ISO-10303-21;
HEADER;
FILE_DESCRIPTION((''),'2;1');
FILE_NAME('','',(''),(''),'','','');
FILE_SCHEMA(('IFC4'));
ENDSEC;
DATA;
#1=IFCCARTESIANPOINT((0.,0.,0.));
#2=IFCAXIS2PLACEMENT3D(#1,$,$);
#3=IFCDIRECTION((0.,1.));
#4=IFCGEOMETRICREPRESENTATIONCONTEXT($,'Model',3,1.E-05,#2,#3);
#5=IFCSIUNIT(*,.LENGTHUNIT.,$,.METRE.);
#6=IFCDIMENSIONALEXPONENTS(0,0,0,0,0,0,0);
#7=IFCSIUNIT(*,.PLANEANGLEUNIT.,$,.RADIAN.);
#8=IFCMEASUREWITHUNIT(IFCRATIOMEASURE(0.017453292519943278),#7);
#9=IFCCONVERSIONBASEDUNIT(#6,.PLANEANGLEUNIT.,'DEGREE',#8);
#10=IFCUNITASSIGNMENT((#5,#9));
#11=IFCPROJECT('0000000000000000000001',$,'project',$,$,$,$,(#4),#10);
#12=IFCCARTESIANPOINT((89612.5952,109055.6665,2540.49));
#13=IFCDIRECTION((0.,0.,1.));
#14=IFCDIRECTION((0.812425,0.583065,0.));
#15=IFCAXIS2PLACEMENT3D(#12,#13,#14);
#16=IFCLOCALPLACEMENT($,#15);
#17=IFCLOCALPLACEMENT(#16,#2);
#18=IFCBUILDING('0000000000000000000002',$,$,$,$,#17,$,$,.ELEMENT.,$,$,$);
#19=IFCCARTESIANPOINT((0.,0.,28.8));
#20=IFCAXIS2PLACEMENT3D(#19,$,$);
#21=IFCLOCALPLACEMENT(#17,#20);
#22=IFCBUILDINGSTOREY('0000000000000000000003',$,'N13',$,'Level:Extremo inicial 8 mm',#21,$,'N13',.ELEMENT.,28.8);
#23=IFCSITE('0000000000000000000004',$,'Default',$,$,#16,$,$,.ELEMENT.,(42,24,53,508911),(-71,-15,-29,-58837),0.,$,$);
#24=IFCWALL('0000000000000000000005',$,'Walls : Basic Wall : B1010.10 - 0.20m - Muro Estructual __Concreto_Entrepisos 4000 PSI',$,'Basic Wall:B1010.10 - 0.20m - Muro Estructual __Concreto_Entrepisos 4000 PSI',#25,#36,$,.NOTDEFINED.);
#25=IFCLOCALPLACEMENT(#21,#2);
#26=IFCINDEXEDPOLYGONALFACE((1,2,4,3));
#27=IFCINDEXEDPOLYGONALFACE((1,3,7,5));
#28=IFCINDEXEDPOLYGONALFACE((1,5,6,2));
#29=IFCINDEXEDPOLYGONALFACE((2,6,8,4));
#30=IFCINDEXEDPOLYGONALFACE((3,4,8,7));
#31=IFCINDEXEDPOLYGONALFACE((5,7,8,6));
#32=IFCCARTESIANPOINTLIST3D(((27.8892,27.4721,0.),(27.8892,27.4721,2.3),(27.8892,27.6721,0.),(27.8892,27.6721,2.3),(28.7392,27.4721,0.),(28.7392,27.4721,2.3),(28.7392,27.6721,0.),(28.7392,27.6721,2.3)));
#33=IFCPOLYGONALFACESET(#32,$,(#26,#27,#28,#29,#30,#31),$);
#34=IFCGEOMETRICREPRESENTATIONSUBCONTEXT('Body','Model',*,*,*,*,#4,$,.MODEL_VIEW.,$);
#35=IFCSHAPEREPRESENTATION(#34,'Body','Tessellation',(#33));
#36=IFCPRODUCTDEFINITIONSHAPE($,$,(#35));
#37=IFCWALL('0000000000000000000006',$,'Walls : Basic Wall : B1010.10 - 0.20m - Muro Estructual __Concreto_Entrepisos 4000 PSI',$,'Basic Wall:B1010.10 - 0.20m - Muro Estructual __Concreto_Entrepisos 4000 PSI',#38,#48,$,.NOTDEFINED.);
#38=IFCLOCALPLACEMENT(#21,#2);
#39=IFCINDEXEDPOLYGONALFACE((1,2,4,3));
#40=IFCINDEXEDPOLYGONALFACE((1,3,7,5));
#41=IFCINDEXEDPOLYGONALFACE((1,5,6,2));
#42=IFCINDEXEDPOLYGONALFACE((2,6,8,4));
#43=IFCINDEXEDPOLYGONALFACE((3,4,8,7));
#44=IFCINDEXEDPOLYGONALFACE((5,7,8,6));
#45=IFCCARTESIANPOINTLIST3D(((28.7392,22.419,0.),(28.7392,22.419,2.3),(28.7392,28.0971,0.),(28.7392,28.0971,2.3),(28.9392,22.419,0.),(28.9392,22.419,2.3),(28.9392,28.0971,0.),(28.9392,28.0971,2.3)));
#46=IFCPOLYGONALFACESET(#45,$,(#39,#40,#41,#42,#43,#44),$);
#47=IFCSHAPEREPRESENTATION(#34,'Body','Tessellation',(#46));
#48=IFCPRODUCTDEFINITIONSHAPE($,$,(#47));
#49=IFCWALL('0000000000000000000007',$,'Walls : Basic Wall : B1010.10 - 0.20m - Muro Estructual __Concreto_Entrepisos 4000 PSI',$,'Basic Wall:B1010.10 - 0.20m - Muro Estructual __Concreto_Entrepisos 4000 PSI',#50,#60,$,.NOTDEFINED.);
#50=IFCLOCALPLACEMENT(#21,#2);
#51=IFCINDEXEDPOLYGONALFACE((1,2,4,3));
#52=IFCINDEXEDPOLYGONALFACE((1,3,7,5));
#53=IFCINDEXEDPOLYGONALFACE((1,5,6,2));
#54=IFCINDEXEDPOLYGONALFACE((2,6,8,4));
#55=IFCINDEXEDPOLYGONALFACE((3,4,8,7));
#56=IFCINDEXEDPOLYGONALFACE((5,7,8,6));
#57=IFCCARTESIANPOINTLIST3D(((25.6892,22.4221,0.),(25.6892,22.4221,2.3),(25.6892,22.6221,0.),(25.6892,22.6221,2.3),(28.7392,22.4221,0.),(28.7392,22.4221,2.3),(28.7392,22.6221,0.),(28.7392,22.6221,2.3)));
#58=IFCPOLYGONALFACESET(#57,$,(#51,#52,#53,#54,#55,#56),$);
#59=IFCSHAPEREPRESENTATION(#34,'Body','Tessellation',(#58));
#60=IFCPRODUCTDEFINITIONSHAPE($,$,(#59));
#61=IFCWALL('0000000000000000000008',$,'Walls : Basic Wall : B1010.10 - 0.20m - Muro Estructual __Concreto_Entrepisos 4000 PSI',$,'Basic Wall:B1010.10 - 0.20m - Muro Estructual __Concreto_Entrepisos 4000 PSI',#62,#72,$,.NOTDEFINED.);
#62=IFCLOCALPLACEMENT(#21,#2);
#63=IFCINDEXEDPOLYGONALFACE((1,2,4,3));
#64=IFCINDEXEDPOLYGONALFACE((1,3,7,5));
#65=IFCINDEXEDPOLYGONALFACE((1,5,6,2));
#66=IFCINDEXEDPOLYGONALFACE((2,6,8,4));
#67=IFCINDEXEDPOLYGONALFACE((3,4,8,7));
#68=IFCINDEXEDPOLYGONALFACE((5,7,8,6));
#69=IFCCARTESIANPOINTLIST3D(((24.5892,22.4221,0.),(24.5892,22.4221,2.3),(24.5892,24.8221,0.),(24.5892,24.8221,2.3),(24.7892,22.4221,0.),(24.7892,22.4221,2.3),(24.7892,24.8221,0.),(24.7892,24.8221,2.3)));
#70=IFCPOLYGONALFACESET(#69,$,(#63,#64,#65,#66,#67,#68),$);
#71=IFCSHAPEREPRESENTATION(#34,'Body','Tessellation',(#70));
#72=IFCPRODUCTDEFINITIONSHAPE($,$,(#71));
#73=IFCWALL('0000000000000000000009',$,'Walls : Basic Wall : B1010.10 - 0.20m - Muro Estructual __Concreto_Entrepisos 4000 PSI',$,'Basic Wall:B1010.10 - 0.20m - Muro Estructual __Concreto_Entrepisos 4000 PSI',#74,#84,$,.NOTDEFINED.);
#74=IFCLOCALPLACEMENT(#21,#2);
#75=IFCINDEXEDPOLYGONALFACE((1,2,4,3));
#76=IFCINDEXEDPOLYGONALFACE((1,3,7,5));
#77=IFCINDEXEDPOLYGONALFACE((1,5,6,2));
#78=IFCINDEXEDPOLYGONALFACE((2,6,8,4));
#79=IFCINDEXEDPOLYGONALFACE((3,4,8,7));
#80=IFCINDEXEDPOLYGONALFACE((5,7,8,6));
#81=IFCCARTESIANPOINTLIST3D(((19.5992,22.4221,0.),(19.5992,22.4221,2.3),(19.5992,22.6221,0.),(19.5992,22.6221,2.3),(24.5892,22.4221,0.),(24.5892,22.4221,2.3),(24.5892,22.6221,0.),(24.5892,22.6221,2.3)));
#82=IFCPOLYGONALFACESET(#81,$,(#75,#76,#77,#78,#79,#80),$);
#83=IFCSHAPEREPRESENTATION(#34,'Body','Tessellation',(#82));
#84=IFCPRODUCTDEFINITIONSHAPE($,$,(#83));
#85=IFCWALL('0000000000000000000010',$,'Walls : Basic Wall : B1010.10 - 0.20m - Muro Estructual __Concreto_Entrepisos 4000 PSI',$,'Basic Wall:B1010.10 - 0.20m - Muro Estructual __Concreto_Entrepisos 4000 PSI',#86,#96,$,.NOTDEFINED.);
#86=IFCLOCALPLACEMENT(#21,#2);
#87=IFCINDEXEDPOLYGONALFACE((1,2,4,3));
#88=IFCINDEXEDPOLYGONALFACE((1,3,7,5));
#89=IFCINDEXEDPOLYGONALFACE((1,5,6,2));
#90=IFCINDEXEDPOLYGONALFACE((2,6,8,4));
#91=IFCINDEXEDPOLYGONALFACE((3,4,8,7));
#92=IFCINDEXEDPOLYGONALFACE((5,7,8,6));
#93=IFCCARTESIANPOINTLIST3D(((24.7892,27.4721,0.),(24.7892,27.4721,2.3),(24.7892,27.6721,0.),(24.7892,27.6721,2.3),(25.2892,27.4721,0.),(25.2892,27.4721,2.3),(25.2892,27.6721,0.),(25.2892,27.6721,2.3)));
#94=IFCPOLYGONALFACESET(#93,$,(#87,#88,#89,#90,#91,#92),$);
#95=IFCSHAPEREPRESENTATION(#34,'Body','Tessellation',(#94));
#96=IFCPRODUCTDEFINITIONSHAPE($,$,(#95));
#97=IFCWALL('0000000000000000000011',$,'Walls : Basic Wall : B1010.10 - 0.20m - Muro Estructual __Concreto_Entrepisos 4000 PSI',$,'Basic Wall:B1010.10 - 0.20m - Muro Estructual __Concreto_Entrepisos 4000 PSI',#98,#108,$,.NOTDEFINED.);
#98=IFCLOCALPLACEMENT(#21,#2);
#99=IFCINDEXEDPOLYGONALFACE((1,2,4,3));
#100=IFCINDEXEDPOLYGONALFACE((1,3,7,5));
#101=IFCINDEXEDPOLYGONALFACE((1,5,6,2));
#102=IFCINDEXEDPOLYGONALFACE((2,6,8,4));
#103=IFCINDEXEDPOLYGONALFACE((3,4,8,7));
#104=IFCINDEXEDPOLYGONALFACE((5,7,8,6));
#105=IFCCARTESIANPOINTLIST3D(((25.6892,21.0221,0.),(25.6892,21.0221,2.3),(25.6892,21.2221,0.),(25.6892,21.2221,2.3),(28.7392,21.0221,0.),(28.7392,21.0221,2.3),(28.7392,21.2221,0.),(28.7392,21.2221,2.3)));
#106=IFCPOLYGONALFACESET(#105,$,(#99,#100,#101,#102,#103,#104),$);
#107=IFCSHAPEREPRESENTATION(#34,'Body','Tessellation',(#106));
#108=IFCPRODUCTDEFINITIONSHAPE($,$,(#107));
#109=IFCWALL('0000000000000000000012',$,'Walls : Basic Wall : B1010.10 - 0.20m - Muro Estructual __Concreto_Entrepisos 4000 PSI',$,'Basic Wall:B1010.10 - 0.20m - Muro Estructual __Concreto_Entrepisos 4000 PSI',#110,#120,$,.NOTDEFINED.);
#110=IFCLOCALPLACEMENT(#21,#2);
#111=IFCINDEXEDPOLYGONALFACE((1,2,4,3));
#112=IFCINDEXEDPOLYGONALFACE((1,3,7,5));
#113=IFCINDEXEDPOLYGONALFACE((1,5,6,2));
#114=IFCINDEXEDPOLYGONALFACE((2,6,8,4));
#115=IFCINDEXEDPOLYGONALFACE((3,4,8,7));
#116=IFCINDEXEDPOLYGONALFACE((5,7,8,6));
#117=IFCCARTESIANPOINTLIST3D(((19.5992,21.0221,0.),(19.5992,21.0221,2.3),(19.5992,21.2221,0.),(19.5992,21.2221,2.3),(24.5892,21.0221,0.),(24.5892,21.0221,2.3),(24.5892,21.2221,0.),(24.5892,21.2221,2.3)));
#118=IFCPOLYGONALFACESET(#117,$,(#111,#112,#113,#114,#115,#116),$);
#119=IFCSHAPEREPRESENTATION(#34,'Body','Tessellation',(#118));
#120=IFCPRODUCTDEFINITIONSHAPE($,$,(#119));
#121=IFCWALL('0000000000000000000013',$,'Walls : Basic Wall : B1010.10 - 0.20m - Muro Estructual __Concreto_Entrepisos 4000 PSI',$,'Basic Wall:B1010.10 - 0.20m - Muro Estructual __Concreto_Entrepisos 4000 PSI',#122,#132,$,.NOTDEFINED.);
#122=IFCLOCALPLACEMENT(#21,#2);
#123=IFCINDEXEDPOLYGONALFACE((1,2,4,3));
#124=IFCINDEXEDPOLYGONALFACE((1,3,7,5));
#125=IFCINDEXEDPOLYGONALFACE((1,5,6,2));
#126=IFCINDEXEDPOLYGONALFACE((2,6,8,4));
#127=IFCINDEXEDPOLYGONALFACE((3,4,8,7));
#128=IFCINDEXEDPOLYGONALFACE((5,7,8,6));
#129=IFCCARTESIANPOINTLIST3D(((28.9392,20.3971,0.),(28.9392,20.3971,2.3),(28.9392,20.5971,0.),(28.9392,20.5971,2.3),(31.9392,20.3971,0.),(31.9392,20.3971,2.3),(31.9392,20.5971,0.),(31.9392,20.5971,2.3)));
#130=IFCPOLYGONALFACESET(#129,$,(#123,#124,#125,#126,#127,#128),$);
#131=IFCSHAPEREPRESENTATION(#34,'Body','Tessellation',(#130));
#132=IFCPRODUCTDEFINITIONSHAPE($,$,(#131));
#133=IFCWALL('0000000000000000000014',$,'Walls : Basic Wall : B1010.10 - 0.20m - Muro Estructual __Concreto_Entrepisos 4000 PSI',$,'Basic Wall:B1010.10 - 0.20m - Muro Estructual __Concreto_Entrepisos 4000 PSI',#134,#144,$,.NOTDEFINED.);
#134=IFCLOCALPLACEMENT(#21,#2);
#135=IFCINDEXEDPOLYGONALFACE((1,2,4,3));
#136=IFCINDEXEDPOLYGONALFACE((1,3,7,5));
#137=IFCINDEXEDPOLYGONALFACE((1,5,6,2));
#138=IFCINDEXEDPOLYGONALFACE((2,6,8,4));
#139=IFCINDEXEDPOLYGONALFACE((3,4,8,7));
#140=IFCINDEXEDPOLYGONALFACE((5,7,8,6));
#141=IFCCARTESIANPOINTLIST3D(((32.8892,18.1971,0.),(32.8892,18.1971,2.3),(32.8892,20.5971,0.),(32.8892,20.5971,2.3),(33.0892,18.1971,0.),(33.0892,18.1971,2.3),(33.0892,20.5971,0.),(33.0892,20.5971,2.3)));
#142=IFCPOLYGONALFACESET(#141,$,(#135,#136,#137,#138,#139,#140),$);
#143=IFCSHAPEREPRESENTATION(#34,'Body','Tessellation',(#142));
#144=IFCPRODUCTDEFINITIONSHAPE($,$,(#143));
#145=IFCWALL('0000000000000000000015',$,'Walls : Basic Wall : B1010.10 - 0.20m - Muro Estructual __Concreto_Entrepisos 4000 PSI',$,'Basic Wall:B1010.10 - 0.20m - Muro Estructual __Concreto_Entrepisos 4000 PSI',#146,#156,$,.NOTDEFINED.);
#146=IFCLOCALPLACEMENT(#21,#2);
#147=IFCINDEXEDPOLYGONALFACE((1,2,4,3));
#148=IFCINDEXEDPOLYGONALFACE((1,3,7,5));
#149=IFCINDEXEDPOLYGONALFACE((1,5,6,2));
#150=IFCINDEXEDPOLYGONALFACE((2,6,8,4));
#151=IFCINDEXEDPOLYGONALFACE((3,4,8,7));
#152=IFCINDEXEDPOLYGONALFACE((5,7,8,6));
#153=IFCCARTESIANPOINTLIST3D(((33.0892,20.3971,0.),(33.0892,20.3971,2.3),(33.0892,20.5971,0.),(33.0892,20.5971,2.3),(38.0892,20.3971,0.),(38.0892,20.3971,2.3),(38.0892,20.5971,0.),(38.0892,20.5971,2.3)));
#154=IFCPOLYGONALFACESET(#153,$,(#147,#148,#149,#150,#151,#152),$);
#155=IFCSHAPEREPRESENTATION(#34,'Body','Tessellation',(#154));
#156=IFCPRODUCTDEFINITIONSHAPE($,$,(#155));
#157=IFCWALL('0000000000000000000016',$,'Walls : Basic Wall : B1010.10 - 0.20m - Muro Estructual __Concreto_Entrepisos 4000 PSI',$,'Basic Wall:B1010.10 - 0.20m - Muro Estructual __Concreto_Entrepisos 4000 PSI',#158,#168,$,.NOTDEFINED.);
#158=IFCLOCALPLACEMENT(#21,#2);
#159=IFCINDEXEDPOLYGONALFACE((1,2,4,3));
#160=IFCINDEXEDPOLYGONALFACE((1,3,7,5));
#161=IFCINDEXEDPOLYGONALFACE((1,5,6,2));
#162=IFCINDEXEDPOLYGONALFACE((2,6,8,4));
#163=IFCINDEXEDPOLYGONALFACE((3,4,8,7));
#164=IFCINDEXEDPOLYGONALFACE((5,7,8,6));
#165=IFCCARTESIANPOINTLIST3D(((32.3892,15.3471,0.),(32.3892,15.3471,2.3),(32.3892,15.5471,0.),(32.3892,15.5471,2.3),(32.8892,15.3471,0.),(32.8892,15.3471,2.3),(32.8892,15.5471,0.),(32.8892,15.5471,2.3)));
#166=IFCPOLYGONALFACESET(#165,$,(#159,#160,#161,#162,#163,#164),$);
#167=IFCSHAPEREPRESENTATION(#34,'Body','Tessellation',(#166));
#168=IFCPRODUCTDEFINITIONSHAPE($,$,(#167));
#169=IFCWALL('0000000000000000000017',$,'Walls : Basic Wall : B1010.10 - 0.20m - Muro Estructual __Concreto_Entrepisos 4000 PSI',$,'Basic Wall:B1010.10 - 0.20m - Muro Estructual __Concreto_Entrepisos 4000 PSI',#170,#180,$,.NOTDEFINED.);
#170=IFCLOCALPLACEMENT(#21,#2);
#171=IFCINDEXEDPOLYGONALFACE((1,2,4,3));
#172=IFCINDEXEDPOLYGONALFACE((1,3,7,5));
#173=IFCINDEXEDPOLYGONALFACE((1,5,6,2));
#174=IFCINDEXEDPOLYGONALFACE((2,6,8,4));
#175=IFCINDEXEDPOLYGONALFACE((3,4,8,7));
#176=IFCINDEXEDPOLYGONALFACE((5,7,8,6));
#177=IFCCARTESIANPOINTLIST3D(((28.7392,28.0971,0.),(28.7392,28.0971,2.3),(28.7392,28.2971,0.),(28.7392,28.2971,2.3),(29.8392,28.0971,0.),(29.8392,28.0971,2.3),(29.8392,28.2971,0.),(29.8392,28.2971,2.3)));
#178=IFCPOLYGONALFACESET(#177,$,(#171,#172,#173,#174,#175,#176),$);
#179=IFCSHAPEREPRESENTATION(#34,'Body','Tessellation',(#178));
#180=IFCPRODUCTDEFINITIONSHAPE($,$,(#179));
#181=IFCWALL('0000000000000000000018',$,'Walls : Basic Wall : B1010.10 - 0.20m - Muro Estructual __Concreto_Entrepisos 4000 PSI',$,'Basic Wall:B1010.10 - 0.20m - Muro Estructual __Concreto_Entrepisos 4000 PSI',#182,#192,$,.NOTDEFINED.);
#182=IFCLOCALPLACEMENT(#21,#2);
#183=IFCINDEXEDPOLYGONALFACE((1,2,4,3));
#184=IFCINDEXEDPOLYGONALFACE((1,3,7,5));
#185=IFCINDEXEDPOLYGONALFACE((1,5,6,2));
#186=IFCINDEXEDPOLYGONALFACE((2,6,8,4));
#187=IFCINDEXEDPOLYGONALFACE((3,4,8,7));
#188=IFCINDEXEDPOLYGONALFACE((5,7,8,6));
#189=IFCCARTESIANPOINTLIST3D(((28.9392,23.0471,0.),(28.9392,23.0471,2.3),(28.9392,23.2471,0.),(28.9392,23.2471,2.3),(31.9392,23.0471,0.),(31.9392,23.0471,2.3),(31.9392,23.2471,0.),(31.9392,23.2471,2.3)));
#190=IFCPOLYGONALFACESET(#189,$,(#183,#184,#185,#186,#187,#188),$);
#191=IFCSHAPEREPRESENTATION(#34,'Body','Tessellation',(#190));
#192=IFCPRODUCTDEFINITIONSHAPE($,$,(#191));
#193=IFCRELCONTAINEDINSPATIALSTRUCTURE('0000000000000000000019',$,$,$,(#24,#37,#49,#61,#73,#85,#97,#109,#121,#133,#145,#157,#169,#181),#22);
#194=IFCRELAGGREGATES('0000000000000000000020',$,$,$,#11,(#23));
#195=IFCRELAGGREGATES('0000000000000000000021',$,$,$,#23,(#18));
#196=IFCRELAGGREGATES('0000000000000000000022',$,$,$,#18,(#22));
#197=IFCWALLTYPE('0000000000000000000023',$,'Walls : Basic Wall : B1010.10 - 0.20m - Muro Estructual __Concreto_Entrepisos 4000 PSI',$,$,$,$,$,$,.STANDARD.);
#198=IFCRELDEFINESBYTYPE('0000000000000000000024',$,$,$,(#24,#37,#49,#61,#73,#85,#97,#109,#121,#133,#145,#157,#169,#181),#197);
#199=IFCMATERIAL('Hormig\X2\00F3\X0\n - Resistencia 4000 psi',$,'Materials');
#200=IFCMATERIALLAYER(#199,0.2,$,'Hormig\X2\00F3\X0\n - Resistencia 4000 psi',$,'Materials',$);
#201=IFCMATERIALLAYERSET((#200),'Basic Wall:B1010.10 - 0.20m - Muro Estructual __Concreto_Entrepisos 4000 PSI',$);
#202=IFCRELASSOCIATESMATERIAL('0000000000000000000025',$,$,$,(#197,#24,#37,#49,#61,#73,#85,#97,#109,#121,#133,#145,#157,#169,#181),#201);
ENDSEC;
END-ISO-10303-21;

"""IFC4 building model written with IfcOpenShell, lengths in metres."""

from ifc_helpers import new_model, entity, si_unit, converted_unit, direction, frame, frame_2d, origin, place, context, subcontext, project, spatial, rectangle, extrude, material, layer, layer_set, layer_usage, type_object, element, save


model = new_model("IFC4")

# Units and contexts
model_context = context("Model", 3, precision=1e-05, world=origin(), true_north=direction((0.0, 1.0)))
body_context = subcontext(model_context, "Body", "Model", "MODEL_VIEW")
ifc_project = project(units=[si_unit("LENGTHUNIT", "METRE"), converted_unit("PLANEANGLEUNIT", "DEGREE", entity("IfcRatioMeasure", 0.017453292519943278), si_unit("PLANEANGLEUNIT", "RADIAN"), dimensions=[0, 0, 0, 0, 0, 0, 0])], contexts=[model_context])

# Site, building, storey
site_placement = place(None, frame((89612.5952, 109055.6665, 2540.49), z_axis=(0.0, 0.0, 1.0), x_axis=(0.812425, 0.583065, 0.0)))
site = spatial("IfcSite", under=ifc_project, at=site_placement, Name="Default", CompositionType="ELEMENT", RefLatitude=(42, 24, 53, 508911), RefLongitude=(-71, -15, -29, -58837), RefElevation=0.0)
building_placement = place(site_placement, origin())
building = spatial("IfcBuilding", under=site, at=building_placement, CompositionType="ELEMENT")
storey_placement = place(building_placement, frame((0.0, 0.0, 28.8)))
storey = spatial("IfcBuildingStorey", under=building, at=storey_placement, Name="N13", ObjectType="Level:Extremo inicial 8 mm", LongName="N13", CompositionType="ELEMENT", Elevation=28.8)

# Walls
ifc_material = material(Name="Hormigón - Resistencia 4000 psi", Category="Materials")
ifc_layer_1 = layer(ifc_material, 0.2, Name="Hormigón - Resistencia 4000 psi", Category="Materials")
ifc_layer_set_1 = layer_set([ifc_layer_1], Name="Basic Wall:B1010.10 - 0.20m - Muro Estructual __Concreto_Entrepisos 4000 PSI")
ifc_layer_usage_1 = layer_usage(ifc_layer_set_1, "AXIS2", "NEGATIVE", 0.1)
wall_type_1 = type_object("IfcWallType", Name="Walls : Basic Wall : B1010.10 - 0.20m - Muro Estructual __Concreto_Entrepisos 4000 PSI", PredefinedType="STANDARD", material=ifc_layer_set_1)
wall_1_placement = place(storey_placement, frame((27.8892, 27.5721, 0.0)))
element("IfcWall", 1, at=wall_1_placement, inside=storey, type_object=wall_type_1, material=ifc_layer_usage_1, Name="Walls : Basic Wall : B1010.10 - 0.20m - Muro Estructual __Concreto_Entrepisos 4000 PSI", ObjectType="Basic Wall:B1010.10 - 0.20m - Muro Estructual __Concreto_Entrepisos 4000 PSI", PredefinedType="NOTDEFINED", context=body_context, shape_type="SweptSolid", body=[
    extrude(rectangle(XDim=0.85, YDim=0.2, at=frame_2d((0.425, 0.0), x_axis=(-1.0, 0.0))), origin(), (0.0, 0.0, 1.0), 2.3),
])
ifc_layer_usage_2 = layer_usage(ifc_layer_set_1, "AXIS2", "NEGATIVE", 0.1)
wall_2_placement = place(storey_placement, frame((28.8392, 28.0971, 0.0), z_axis=(0.0, 0.0, 1.0), x_axis=(0.0, -1.0, 0.0)))
element("IfcWall", 2, at=wall_2_placement, inside=storey, type_object=wall_type_1, material=ifc_layer_usage_2, Name="Walls : Basic Wall : B1010.10 - 0.20m - Muro Estructual __Concreto_Entrepisos 4000 PSI", ObjectType="Basic Wall:B1010.10 - 0.20m - Muro Estructual __Concreto_Entrepisos 4000 PSI", PredefinedType="NOTDEFINED", context=body_context, shape_type="SweptSolid", body=[
    extrude(rectangle(XDim=5.6781, YDim=0.2, at=frame_2d((2.839, 0.0), x_axis=(-1.0, 0.0))), origin(), (0.0, 0.0, 1.0), 2.3),
])
ifc_layer_usage_3 = layer_usage(ifc_layer_set_1, "AXIS2", "NEGATIVE", 0.1)
wall_3_placement = place(storey_placement, frame((28.7392, 22.5221, 0.0), z_axis=(0.0, 0.0, 1.0), x_axis=(-1.0, 0.0, 0.0)))
element("IfcWall", 3, at=wall_3_placement, inside=storey, type_object=wall_type_1, material=ifc_layer_usage_3, Name="Walls : Basic Wall : B1010.10 - 0.20m - Muro Estructual __Concreto_Entrepisos 4000 PSI", ObjectType="Basic Wall:B1010.10 - 0.20m - Muro Estructual __Concreto_Entrepisos 4000 PSI", PredefinedType="NOTDEFINED", context=body_context, shape_type="SweptSolid", body=[
    extrude(rectangle(XDim=3.05, YDim=0.2, at=frame_2d((1.525, 0.0), x_axis=(-1.0, 0.0))), origin(), (0.0, 0.0, 1.0), 2.3),
])
ifc_layer_usage_4 = layer_usage(ifc_layer_set_1, "AXIS2", "NEGATIVE", 0.1)
wall_4_placement = place(storey_placement, frame((24.6892, 24.8221, 0.0), z_axis=(0.0, 0.0, 1.0), x_axis=(0.0, -1.0, 0.0)))
element("IfcWall", 4, at=wall_4_placement, inside=storey, type_object=wall_type_1, material=ifc_layer_usage_4, Name="Walls : Basic Wall : B1010.10 - 0.20m - Muro Estructual __Concreto_Entrepisos 4000 PSI", ObjectType="Basic Wall:B1010.10 - 0.20m - Muro Estructual __Concreto_Entrepisos 4000 PSI", PredefinedType="NOTDEFINED", context=body_context, shape_type="SweptSolid", body=[
    extrude(rectangle(XDim=2.4, YDim=0.2, at=frame_2d((1.2, 0.0), x_axis=(-1.0, 0.0))), origin(), (0.0, 0.0, 1.0), 2.3),
])
ifc_layer_usage_5 = layer_usage(ifc_layer_set_1, "AXIS2", "NEGATIVE", 0.1)
wall_5_placement = place(storey_placement, frame((24.5892, 22.5221, 0.0), z_axis=(0.0, 0.0, 1.0), x_axis=(-1.0, 0.0, 0.0)))
element("IfcWall", 5, at=wall_5_placement, inside=storey, type_object=wall_type_1, material=ifc_layer_usage_5, Name="Walls : Basic Wall : B1010.10 - 0.20m - Muro Estructual __Concreto_Entrepisos 4000 PSI", ObjectType="Basic Wall:B1010.10 - 0.20m - Muro Estructual __Concreto_Entrepisos 4000 PSI", PredefinedType="NOTDEFINED", context=body_context, shape_type="SweptSolid", body=[
    extrude(rectangle(XDim=4.99, YDim=0.2, at=frame_2d((2.495, 0.0), x_axis=(-1.0, 0.0))), origin(), (0.0, 0.0, 1.0), 2.3),
])
ifc_layer_usage_6 = layer_usage(ifc_layer_set_1, "AXIS2", "NEGATIVE", 0.1)
wall_6_placement = place(storey_placement, frame((25.2892, 27.5721, 0.0), z_axis=(0.0, 0.0, 1.0), x_axis=(-1.0, 0.0, 0.0)))
element("IfcWall", 6, at=wall_6_placement, inside=storey, type_object=wall_type_1, material=ifc_layer_usage_6, Name="Walls : Basic Wall : B1010.10 - 0.20m - Muro Estructual __Concreto_Entrepisos 4000 PSI", ObjectType="Basic Wall:B1010.10 - 0.20m - Muro Estructual __Concreto_Entrepisos 4000 PSI", PredefinedType="NOTDEFINED", context=body_context, shape_type="SweptSolid", body=[
    extrude(rectangle(XDim=0.5, YDim=0.2, at=frame_2d((0.25, 0.0), x_axis=(-1.0, 0.0))), origin(), (0.0, 0.0, 1.0), 2.3),
])
ifc_layer_usage_7 = layer_usage(ifc_layer_set_1, "AXIS2", "POSITIVE", -0.1)
wall_7_placement = place(storey_placement, frame((28.7392, 21.1221, 0.0), z_axis=(0.0, 0.0, 1.0), x_axis=(-1.0, 0.0, 0.0)))
element("IfcWall", 7, at=wall_7_placement, inside=storey, type_object=wall_type_1, material=ifc_layer_usage_7, Name="Walls : Basic Wall : B1010.10 - 0.20m - Muro Estructual __Concreto_Entrepisos 4000 PSI", ObjectType="Basic Wall:B1010.10 - 0.20m - Muro Estructual __Concreto_Entrepisos 4000 PSI", PredefinedType="NOTDEFINED", context=body_context, shape_type="SweptSolid", body=[
    extrude(rectangle(XDim=3.05, YDim=0.2, at=frame_2d((1.525, 0.0), x_axis=(-1.0, 0.0))), origin(), (0.0, 0.0, 1.0), 2.3),
])
ifc_layer_usage_8 = layer_usage(ifc_layer_set_1, "AXIS2", "POSITIVE", -0.1)
wall_8_placement = place(storey_placement, frame((24.5892, 21.1221, 0.0), z_axis=(0.0, 0.0, 1.0), x_axis=(-1.0, 0.0, 0.0)))
element("IfcWall", 8, at=wall_8_placement, inside=storey, type_object=wall_type_1, material=ifc_layer_usage_8, Name="Walls : Basic Wall : B1010.10 - 0.20m - Muro Estructual __Concreto_Entrepisos 4000 PSI", ObjectType="Basic Wall:B1010.10 - 0.20m - Muro Estructual __Concreto_Entrepisos 4000 PSI", PredefinedType="NOTDEFINED", context=body_context, shape_type="SweptSolid", body=[
    extrude(rectangle(XDim=4.99, YDim=0.2, at=frame_2d((2.495, 0.0), x_axis=(-1.0, 0.0))), origin(), (0.0, 0.0, 1.0), 2.3),
])
ifc_layer_usage_9 = layer_usage(ifc_layer_set_1, "AXIS2", "NEGATIVE", 0.1)
wall_9_placement = place(storey_placement, frame((28.9392, 20.4971, 0.0)))
element("IfcWall", 9, at=wall_9_placement, inside=storey, type_object=wall_type_1, material=ifc_layer_usage_9, Name="Walls : Basic Wall : B1010.10 - 0.20m - Muro Estructual __Concreto_Entrepisos 4000 PSI", ObjectType="Basic Wall:B1010.10 - 0.20m - Muro Estructual __Concreto_Entrepisos 4000 PSI", PredefinedType="NOTDEFINED", context=body_context, shape_type="SweptSolid", body=[
    extrude(rectangle(XDim=3.0, YDim=0.2, at=frame_2d((1.5, 0.0), x_axis=(-1.0, 0.0))), origin(), (0.0, 0.0, 1.0), 2.3),
])
ifc_layer_usage_10 = layer_usage(ifc_layer_set_1, "AXIS2", "NEGATIVE", 0.1)
wall_10_placement = place(storey_placement, frame((32.9892, 18.1971, 0.0), z_axis=(0.0, 0.0, 1.0), x_axis=(0.0, 1.0, 0.0)))
element("IfcWall", 10, at=wall_10_placement, inside=storey, type_object=wall_type_1, material=ifc_layer_usage_10, Name="Walls : Basic Wall : B1010.10 - 0.20m - Muro Estructual __Concreto_Entrepisos 4000 PSI", ObjectType="Basic Wall:B1010.10 - 0.20m - Muro Estructual __Concreto_Entrepisos 4000 PSI", PredefinedType="NOTDEFINED", context=body_context, shape_type="SweptSolid", body=[
    extrude(rectangle(XDim=2.4, YDim=0.2, at=frame_2d((1.2, 0.0), x_axis=(-1.0, 0.0))), origin(), (0.0, 0.0, 1.0), 2.3),
])
ifc_layer_usage_11 = layer_usage(ifc_layer_set_1, "AXIS2", "NEGATIVE", 0.1)
wall_11_placement = place(storey_placement, frame((33.0892, 20.4971, 0.0)))
element("IfcWall", 11, at=wall_11_placement, inside=storey, type_object=wall_type_1, material=ifc_layer_usage_11, Name="Walls : Basic Wall : B1010.10 - 0.20m - Muro Estructual __Concreto_Entrepisos 4000 PSI", ObjectType="Basic Wall:B1010.10 - 0.20m - Muro Estructual __Concreto_Entrepisos 4000 PSI", PredefinedType="NOTDEFINED", context=body_context, shape_type="SweptSolid", body=[
    extrude(rectangle(XDim=5.0, YDim=0.2, at=frame_2d((2.5, 0.0), x_axis=(-1.0, 0.0))), origin(), (0.0, 0.0, 1.0), 2.3),
])
ifc_layer_usage_12 = layer_usage(ifc_layer_set_1, "AXIS2", "NEGATIVE", 0.1)
wall_12_placement = place(storey_placement, frame((32.3892, 15.4471, 0.0)))
element("IfcWall", 12, at=wall_12_placement, inside=storey, type_object=wall_type_1, material=ifc_layer_usage_12, Name="Walls : Basic Wall : B1010.10 - 0.20m - Muro Estructual __Concreto_Entrepisos 4000 PSI", ObjectType="Basic Wall:B1010.10 - 0.20m - Muro Estructual __Concreto_Entrepisos 4000 PSI", PredefinedType="NOTDEFINED", context=body_context, shape_type="SweptSolid", body=[
    extrude(rectangle(XDim=0.5, YDim=0.2, at=frame_2d((0.25, 0.0), x_axis=(-1.0, 0.0))), origin(), (0.0, 0.0, 1.0), 2.3),
])
ifc_layer_usage_13 = layer_usage(ifc_layer_set_1, "AXIS2", "POSITIVE", -0.1)
wall_13_placement = place(storey_placement, frame((29.8392, 28.1971, 0.0), z_axis=(0.0, 0.0, 1.0), x_axis=(-1.0, 0.0, 0.0)))
element("IfcWall", 13, at=wall_13_placement, inside=storey, type_object=wall_type_1, material=ifc_layer_usage_13, Name="Walls : Basic Wall : B1010.10 - 0.20m - Muro Estructual __Concreto_Entrepisos 4000 PSI", ObjectType="Basic Wall:B1010.10 - 0.20m - Muro Estructual __Concreto_Entrepisos 4000 PSI", PredefinedType="NOTDEFINED", context=body_context, shape_type="SweptSolid", body=[
    extrude(rectangle(XDim=1.1, YDim=0.2, at=frame_2d((0.55, 0.0), x_axis=(-1.0, 0.0))), origin(), (0.0, 0.0, 1.0), 2.3),
])
ifc_layer_usage_14 = layer_usage(ifc_layer_set_1, "AXIS2", "POSITIVE", -0.1)
wall_14_placement = place(storey_placement, frame((28.9392, 23.1471, 0.0)))
element("IfcWall", 14, at=wall_14_placement, inside=storey, type_object=wall_type_1, material=ifc_layer_usage_14, Name="Walls : Basic Wall : B1010.10 - 0.20m - Muro Estructual __Concreto_Entrepisos 4000 PSI", ObjectType="Basic Wall:B1010.10 - 0.20m - Muro Estructual __Concreto_Entrepisos 4000 PSI", PredefinedType="NOTDEFINED", context=body_context, shape_type="SweptSolid", body=[
    extrude(rectangle(XDim=3.0, YDim=0.2, at=frame_2d((1.5, 0.0), x_axis=(-1.0, 0.0))), origin(), (0.0, 0.0, 1.0), 2.3),
])

save(model, "model.ifc")
